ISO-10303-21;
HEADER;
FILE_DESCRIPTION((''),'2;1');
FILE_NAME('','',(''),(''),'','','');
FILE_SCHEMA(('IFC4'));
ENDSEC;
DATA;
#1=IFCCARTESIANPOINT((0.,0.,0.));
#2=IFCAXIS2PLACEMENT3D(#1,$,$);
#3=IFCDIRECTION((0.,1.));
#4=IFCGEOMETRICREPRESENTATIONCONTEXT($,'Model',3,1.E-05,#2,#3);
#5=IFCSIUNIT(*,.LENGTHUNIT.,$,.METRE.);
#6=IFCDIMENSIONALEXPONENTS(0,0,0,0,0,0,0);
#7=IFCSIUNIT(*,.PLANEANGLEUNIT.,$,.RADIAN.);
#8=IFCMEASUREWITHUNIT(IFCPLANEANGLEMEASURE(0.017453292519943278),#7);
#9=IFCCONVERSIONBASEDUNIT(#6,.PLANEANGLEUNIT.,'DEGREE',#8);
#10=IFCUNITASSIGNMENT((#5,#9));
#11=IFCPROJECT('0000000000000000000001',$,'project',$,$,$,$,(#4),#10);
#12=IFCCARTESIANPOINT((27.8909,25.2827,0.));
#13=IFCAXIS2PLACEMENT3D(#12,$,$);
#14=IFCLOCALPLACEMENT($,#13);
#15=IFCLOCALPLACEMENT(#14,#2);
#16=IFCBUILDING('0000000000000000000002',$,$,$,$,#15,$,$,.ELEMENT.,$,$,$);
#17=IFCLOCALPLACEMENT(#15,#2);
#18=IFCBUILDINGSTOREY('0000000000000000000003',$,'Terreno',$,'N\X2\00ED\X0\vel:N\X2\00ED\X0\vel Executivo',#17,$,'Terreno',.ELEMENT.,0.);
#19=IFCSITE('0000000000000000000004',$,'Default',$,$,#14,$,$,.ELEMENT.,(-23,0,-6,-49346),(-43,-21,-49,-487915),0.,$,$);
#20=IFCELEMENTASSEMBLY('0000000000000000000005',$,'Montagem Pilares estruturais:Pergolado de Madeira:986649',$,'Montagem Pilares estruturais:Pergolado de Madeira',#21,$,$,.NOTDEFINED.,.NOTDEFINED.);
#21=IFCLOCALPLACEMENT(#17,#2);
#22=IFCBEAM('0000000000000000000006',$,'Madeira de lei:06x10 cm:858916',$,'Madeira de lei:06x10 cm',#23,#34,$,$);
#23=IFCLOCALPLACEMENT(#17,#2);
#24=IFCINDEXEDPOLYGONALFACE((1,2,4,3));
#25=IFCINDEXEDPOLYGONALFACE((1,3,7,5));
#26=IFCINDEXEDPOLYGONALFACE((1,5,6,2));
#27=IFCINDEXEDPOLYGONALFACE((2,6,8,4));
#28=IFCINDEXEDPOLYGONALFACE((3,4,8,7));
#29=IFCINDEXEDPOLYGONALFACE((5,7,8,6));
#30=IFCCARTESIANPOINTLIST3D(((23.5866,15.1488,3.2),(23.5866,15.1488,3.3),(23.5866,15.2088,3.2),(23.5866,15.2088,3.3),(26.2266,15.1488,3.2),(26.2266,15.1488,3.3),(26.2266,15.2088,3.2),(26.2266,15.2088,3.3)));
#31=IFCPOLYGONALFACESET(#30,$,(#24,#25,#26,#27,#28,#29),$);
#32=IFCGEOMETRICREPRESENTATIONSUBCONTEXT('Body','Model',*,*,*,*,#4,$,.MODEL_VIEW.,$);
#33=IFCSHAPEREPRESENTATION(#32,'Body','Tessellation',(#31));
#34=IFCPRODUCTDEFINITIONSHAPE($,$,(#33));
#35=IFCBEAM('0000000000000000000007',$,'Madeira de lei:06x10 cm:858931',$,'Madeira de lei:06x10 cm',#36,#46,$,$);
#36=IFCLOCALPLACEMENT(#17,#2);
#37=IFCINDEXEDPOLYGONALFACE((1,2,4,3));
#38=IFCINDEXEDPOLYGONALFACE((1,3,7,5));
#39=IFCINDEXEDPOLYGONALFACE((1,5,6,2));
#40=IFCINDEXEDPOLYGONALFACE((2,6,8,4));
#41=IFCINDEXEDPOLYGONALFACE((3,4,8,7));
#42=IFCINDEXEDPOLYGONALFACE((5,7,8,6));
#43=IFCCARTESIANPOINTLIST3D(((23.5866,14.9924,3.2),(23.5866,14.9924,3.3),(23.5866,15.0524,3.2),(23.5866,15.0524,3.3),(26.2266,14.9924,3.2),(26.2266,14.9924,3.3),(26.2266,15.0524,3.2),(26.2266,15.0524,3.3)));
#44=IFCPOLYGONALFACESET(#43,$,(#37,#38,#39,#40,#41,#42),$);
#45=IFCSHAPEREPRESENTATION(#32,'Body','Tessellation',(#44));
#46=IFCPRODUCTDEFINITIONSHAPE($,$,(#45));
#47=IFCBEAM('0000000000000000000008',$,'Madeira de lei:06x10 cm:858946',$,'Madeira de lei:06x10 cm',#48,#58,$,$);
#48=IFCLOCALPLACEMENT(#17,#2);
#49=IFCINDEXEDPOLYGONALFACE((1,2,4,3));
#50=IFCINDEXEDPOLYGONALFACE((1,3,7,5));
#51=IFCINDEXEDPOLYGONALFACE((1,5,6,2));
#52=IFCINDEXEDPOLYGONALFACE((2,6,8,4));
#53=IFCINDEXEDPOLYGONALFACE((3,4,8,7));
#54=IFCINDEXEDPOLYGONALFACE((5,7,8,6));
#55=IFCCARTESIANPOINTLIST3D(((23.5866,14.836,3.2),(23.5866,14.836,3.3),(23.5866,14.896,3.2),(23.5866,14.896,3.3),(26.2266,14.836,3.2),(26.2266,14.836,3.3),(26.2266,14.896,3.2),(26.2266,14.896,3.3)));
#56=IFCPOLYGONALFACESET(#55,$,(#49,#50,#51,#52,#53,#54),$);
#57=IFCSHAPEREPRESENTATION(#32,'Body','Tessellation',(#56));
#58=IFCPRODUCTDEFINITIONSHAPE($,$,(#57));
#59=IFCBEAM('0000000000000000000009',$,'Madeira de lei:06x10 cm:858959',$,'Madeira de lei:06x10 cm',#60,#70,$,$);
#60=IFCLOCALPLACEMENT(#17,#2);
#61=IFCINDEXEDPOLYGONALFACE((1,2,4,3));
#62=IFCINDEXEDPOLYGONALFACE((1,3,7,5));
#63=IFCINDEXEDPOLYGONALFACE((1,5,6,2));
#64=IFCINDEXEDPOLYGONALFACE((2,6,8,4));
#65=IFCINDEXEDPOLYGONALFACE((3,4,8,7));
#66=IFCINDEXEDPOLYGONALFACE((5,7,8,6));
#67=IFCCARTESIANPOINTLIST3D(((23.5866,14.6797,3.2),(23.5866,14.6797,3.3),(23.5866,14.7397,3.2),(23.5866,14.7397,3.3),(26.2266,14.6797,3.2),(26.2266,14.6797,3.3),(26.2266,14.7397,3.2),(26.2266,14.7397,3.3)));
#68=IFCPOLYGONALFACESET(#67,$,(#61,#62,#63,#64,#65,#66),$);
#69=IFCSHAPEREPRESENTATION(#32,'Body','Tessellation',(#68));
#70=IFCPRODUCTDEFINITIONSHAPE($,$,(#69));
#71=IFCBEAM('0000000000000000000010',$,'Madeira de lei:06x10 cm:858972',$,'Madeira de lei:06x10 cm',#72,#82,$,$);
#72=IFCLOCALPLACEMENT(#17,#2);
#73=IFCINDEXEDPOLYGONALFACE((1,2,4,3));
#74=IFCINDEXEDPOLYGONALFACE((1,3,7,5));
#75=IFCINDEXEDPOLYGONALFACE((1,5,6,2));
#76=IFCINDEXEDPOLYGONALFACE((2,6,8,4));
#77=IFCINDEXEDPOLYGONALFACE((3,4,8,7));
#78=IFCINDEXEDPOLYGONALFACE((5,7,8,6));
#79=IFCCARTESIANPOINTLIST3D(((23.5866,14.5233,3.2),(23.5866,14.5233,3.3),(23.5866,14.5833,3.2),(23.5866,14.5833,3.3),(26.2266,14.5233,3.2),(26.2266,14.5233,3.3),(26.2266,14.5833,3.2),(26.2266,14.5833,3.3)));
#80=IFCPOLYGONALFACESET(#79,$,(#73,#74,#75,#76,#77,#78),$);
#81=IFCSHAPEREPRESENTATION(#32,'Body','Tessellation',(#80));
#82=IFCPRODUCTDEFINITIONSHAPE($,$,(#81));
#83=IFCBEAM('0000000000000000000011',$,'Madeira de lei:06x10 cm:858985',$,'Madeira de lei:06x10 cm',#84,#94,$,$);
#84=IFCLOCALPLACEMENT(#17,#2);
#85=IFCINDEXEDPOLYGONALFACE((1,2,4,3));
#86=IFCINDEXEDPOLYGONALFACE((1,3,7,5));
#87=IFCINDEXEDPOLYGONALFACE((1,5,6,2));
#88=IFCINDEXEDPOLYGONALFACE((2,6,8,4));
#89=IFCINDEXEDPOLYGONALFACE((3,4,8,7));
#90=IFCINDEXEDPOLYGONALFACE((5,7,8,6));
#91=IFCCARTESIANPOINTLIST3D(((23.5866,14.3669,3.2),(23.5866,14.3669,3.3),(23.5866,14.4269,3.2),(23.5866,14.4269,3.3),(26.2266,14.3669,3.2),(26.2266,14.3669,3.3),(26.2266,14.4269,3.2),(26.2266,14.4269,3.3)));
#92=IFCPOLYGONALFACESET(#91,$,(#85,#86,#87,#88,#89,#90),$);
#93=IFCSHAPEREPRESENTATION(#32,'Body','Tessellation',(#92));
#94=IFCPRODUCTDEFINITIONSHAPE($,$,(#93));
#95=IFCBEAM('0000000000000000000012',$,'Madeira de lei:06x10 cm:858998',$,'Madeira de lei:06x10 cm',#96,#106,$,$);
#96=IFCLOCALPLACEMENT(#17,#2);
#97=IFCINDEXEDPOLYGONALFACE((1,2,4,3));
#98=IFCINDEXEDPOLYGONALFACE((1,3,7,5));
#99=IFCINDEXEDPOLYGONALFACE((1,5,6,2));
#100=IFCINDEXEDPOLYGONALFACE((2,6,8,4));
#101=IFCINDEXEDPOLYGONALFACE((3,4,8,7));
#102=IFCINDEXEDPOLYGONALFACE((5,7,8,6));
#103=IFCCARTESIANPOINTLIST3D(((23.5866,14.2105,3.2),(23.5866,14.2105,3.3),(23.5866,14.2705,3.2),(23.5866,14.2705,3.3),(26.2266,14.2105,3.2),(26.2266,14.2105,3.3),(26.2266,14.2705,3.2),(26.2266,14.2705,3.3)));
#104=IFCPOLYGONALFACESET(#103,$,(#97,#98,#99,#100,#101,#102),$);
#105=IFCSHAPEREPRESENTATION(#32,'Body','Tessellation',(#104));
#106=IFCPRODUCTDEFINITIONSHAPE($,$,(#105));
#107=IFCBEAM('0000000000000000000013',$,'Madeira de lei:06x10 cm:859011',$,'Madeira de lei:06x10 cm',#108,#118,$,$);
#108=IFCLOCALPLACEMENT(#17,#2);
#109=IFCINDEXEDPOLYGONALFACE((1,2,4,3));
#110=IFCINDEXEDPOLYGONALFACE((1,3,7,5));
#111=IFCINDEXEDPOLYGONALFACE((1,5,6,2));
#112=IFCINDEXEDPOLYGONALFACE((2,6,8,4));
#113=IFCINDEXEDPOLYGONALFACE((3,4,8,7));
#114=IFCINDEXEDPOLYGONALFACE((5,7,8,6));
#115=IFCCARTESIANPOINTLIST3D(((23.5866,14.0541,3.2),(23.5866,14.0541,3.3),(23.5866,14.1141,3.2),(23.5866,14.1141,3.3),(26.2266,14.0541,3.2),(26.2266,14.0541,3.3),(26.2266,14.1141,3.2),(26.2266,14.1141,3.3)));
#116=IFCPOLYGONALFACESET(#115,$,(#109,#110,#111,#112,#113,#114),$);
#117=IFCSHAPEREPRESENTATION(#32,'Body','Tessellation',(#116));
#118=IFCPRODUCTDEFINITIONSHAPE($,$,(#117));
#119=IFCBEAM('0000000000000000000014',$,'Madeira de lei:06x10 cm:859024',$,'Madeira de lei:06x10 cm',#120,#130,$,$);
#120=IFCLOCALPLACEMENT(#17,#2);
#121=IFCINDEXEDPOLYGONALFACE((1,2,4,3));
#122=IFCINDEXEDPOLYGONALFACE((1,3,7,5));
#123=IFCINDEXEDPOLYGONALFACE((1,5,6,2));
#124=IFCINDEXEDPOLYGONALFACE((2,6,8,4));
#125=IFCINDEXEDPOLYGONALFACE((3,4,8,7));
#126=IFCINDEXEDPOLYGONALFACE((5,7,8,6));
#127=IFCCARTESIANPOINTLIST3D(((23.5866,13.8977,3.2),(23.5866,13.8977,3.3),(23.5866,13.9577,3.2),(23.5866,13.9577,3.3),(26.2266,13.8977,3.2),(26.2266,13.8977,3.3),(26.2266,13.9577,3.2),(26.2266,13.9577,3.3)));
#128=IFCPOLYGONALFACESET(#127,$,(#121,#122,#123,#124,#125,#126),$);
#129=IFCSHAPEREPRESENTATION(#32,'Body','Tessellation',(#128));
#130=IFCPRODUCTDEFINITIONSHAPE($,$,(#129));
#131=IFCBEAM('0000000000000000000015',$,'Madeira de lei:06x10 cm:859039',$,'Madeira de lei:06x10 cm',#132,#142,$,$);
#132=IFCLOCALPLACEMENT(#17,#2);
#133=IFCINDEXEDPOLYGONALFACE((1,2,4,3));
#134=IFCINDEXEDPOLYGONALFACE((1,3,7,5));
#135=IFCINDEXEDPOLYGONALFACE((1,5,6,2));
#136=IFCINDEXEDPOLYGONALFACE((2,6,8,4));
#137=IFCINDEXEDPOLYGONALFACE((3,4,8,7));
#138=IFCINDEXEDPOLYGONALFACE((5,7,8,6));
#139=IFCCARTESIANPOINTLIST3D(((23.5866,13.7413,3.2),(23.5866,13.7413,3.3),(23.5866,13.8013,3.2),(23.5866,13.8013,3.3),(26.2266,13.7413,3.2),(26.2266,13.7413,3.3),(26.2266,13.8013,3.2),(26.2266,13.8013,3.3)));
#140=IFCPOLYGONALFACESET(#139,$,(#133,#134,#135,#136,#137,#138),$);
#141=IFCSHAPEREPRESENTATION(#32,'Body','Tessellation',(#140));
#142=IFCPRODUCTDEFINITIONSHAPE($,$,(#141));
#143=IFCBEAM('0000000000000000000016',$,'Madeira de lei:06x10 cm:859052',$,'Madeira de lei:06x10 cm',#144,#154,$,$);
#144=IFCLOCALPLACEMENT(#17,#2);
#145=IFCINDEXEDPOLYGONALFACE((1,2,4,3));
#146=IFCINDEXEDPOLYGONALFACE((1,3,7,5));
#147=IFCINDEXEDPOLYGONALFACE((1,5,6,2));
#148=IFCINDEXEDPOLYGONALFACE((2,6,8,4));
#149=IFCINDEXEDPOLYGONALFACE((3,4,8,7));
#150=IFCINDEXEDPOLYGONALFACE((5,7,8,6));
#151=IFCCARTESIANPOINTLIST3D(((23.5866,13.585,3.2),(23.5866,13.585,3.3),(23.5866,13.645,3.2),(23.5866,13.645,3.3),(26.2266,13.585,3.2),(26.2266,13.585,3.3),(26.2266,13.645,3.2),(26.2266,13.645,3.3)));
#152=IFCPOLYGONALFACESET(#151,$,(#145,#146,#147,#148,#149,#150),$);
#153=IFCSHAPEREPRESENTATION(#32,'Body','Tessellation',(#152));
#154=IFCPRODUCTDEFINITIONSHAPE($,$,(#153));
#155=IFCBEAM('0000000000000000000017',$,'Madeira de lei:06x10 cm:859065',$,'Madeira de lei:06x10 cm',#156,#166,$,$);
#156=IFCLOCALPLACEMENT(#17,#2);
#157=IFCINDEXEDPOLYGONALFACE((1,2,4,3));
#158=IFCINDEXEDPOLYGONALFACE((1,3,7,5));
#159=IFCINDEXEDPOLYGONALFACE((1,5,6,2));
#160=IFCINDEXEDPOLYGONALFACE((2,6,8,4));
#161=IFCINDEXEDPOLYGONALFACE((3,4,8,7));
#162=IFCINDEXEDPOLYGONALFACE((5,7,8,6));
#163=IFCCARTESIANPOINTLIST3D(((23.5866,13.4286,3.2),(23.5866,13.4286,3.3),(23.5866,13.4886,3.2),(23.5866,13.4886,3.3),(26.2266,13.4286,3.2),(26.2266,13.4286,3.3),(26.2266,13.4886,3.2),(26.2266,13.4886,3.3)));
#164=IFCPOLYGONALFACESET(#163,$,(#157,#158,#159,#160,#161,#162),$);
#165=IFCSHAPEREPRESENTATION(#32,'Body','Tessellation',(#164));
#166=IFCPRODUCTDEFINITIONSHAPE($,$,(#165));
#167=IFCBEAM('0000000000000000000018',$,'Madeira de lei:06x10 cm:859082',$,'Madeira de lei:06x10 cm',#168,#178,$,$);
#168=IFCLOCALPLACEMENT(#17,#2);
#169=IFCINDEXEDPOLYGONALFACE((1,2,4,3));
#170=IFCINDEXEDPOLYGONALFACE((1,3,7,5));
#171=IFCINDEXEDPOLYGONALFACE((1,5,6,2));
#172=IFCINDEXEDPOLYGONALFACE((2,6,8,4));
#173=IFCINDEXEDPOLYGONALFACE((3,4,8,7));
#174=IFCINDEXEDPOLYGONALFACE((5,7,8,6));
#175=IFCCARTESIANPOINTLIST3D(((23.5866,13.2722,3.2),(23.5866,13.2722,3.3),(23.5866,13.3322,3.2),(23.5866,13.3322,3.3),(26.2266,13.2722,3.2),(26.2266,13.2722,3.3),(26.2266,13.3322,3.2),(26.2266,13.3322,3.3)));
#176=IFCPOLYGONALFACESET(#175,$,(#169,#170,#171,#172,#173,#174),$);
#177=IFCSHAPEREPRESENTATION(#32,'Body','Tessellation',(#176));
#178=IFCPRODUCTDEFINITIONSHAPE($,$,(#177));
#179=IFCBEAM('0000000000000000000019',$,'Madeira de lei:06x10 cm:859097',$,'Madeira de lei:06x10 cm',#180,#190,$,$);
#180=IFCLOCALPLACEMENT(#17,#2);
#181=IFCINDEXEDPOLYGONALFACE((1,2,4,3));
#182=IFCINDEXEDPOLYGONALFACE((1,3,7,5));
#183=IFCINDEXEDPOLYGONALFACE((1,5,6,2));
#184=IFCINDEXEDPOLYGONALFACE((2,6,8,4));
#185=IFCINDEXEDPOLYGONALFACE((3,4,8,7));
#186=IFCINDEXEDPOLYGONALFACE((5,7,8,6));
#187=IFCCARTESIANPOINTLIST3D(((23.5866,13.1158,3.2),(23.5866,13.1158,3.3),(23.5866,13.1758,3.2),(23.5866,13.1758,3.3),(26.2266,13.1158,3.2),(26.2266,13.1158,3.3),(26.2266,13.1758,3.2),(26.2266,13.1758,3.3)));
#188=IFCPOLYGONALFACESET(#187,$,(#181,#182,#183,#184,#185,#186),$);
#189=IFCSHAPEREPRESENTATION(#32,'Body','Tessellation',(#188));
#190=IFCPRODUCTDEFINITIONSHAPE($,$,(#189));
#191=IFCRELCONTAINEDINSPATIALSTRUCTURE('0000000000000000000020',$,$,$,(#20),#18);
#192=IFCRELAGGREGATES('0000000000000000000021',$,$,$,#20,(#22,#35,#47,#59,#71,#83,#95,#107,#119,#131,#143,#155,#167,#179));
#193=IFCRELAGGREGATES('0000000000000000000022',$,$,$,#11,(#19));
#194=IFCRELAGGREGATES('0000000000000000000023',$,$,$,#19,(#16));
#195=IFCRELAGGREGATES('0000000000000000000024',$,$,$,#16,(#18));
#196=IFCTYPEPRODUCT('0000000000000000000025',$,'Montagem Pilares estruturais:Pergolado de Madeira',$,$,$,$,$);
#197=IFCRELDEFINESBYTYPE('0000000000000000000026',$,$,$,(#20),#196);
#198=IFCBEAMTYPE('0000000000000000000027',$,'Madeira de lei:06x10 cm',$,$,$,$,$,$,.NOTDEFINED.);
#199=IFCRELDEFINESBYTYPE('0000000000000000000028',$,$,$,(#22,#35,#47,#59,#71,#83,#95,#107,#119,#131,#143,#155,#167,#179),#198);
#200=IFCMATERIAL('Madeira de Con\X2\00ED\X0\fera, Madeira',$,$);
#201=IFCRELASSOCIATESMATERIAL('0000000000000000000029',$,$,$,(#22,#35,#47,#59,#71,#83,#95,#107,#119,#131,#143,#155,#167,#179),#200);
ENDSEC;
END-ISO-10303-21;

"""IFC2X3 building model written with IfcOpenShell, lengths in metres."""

from ifc_helpers import new_model, entity, si_unit, converted_unit, direction, frame, frame_2d, origin, place, context, subcontext, project, spatial, rectangle, extrude, material, type_object, element, aggregate, save


model = new_model("IFC2X3")

# Units and contexts
model_context = context("Model", 3, precision=1e-05, world=origin(), true_north=direction((0.0, 1.0)))
body_context = subcontext(model_context, "Body", "Model", "MODEL_VIEW")
ifc_project = project(units=[si_unit("LENGTHUNIT", "METRE"), converted_unit("PLANEANGLEUNIT", "DEGREE", entity("IfcPlaneAngleMeasure", 0.017453292519943278), si_unit("PLANEANGLEUNIT", "RADIAN"), dimensions=[0, 0, 0, 0, 0, 0, 0])], contexts=[model_context])

# Site, building, storey
site_placement = place(None, frame((27.8909, 25.2827, 0.0)))
site = spatial("IfcSite", under=ifc_project, at=site_placement, Name="Default", CompositionType="ELEMENT", RefLatitude=(-23, 0, -6, -49346), RefLongitude=(-43, -21, -49, -487915), RefElevation=0.0)
building_placement = place(site_placement, origin())
building = spatial("IfcBuilding", under=site, at=building_placement, CompositionType="ELEMENT")
storey_placement = place(building_placement, origin())
storey = spatial("IfcBuildingStorey", under=building, at=storey_placement, Name="Terreno", ObjectType="Nível:Nível Executivo", LongName="Terreno", CompositionType="ELEMENT", Elevation=0.0)

# Element assembly, beams
type_product = type_object("IfcTypeProduct", Name="Montagem Pilares estruturais:Pergolado de Madeira")
assembly_placement = place(storey_placement, origin())
assembly = element("IfcElementAssembly", 1, at=assembly_placement, inside=storey, type_object=type_product, Name="Montagem Pilares estruturais:Pergolado de Madeira:986649", ObjectType="Montagem Pilares estruturais:Pergolado de Madeira", AssemblyPlace="NOTDEFINED", PredefinedType="NOTDEFINED")
ifc_material_1 = material(Name="Madeira de Conífera, Madeira")
beam_type_1 = type_object("IfcBeamType", Name="Madeira de lei:06x10 cm", PredefinedType="NOTDEFINED")
beam_1_placement = place(assembly_placement, frame((23.5866, 15.1788, 3.2)))
beam_1 = element("IfcBeam", 2, at=beam_1_placement, type_object=beam_type_1, material=ifc_material_1, Name="Madeira de lei:06x10 cm:858916", ObjectType="Madeira de lei:06x10 cm", context=body_context, shape_type="SweptSolid", body=[
    extrude(rectangle(XDim=0.1, YDim=0.06, at=frame_2d((0.0, 0.0), x_axis=(1.0, 0.0))), frame((0.0, 0.0, 0.05), z_axis=(1.0, 0.0, 0.0), x_axis=(0.0, 0.0, -1.0)), (0.0, 0.0, 1.0), 2.64),
])
beam_2_placement = place(assembly_placement, frame((23.5866, 15.0224, 3.2)))
beam_2 = element("IfcBeam", 3, at=beam_2_placement, type_object=beam_type_1, material=ifc_material_1, Name="Madeira de lei:06x10 cm:858931", ObjectType="Madeira de lei:06x10 cm", context=body_context, shape_type="SweptSolid", body=[
    extrude(rectangle(XDim=0.1, YDim=0.06, at=frame_2d((0.0, 0.0), x_axis=(1.0, 0.0))), frame((0.0, 0.0, 0.05), z_axis=(1.0, 0.0, 0.0), x_axis=(0.0, 0.0, -1.0)), (0.0, 0.0, 1.0), 2.64),
])
beam_3_placement = place(assembly_placement, frame((23.5866, 14.866, 3.2)))
beam_3 = element("IfcBeam", 4, at=beam_3_placement, type_object=beam_type_1, material=ifc_material_1, Name="Madeira de lei:06x10 cm:858946", ObjectType="Madeira de lei:06x10 cm", context=body_context, shape_type="SweptSolid", body=[
    extrude(rectangle(XDim=0.1, YDim=0.06, at=frame_2d((0.0, 0.0), x_axis=(1.0, 0.0))), frame((0.0, 0.0, 0.05), z_axis=(1.0, 0.0, 0.0), x_axis=(0.0, 0.0, -1.0)), (0.0, 0.0, 1.0), 2.64),
])
beam_4_placement = place(assembly_placement, frame((23.5866, 14.7097, 3.2)))
beam_4 = element("IfcBeam", 5, at=beam_4_placement, type_object=beam_type_1, material=ifc_material_1, Name="Madeira de lei:06x10 cm:858959", ObjectType="Madeira de lei:06x10 cm", context=body_context, shape_type="SweptSolid", body=[
    extrude(rectangle(XDim=0.1, YDim=0.06, at=frame_2d((0.0, 0.0), x_axis=(1.0, 0.0))), frame((0.0, 0.0, 0.05), z_axis=(1.0, 0.0, 0.0), x_axis=(0.0, 0.0, -1.0)), (0.0, 0.0, 1.0), 2.64),
])
beam_5_placement = place(assembly_placement, frame((23.5866, 14.5533, 3.2)))
beam_5 = element("IfcBeam", 6, at=beam_5_placement, type_object=beam_type_1, material=ifc_material_1, Name="Madeira de lei:06x10 cm:858972", ObjectType="Madeira de lei:06x10 cm", context=body_context, shape_type="SweptSolid", body=[
    extrude(rectangle(XDim=0.1, YDim=0.06, at=frame_2d((0.0, 0.0), x_axis=(1.0, 0.0))), frame((0.0, 0.0, 0.05), z_axis=(1.0, 0.0, 0.0), x_axis=(0.0, 0.0, -1.0)), (0.0, 0.0, 1.0), 2.64),
])
beam_6_placement = place(assembly_placement, frame((23.5866, 14.3969, 3.2)))
beam_6 = element("IfcBeam", 7, at=beam_6_placement, type_object=beam_type_1, material=ifc_material_1, Name="Madeira de lei:06x10 cm:858985", ObjectType="Madeira de lei:06x10 cm", context=body_context, shape_type="SweptSolid", body=[
    extrude(rectangle(XDim=0.1, YDim=0.06, at=frame_2d((0.0, 0.0), x_axis=(1.0, 0.0))), frame((0.0, 0.0, 0.05), z_axis=(1.0, 0.0, 0.0), x_axis=(0.0, 0.0, -1.0)), (0.0, 0.0, 1.0), 2.64),
])
beam_7_placement = place(assembly_placement, frame((23.5866, 14.2405, 3.2)))
beam_7 = element("IfcBeam", 8, at=beam_7_placement, type_object=beam_type_1, material=ifc_material_1, Name="Madeira de lei:06x10 cm:858998", ObjectType="Madeira de lei:06x10 cm", context=body_context, shape_type="SweptSolid", body=[
    extrude(rectangle(XDim=0.1, YDim=0.06, at=frame_2d((0.0, 0.0), x_axis=(1.0, 0.0))), frame((0.0, 0.0, 0.05), z_axis=(1.0, 0.0, 0.0), x_axis=(0.0, 0.0, -1.0)), (0.0, 0.0, 1.0), 2.64),
])
beam_8_placement = place(assembly_placement, frame((23.5866, 14.0841, 3.2)))
beam_8 = element("IfcBeam", 9, at=beam_8_placement, type_object=beam_type_1, material=ifc_material_1, Name="Madeira de lei:06x10 cm:859011", ObjectType="Madeira de lei:06x10 cm", context=body_context, shape_type="SweptSolid", body=[
    extrude(rectangle(XDim=0.1, YDim=0.06, at=frame_2d((0.0, 0.0), x_axis=(1.0, 0.0))), frame((0.0, 0.0, 0.05), z_axis=(1.0, 0.0, 0.0), x_axis=(0.0, 0.0, -1.0)), (0.0, 0.0, 1.0), 2.64),
])
beam_9_placement = place(assembly_placement, frame((23.5866, 13.9277, 3.2)))
beam_9 = element("IfcBeam", 10, at=beam_9_placement, type_object=beam_type_1, material=ifc_material_1, Name="Madeira de lei:06x10 cm:859024", ObjectType="Madeira de lei:06x10 cm", context=body_context, shape_type="SweptSolid", body=[
    extrude(rectangle(XDim=0.1, YDim=0.06, at=frame_2d((0.0, 0.0), x_axis=(1.0, 0.0))), frame((0.0, 0.0, 0.05), z_axis=(1.0, 0.0, 0.0), x_axis=(0.0, 0.0, -1.0)), (0.0, 0.0, 1.0), 2.64),
])
beam_10_placement = place(assembly_placement, frame((23.5866, 13.7713, 3.2)))
beam_10 = element("IfcBeam", 11, at=beam_10_placement, type_object=beam_type_1, material=ifc_material_1, Name="Madeira de lei:06x10 cm:859039", ObjectType="Madeira de lei:06x10 cm", context=body_context, shape_type="SweptSolid", body=[
    extrude(rectangle(XDim=0.1, YDim=0.06, at=frame_2d((0.0, 0.0), x_axis=(1.0, 0.0))), frame((0.0, 0.0, 0.05), z_axis=(1.0, 0.0, 0.0), x_axis=(0.0, 0.0, -1.0)), (0.0, 0.0, 1.0), 2.64),
])
beam_11_placement = place(assembly_placement, frame((23.5866, 13.615, 3.2)))
beam_11 = element("IfcBeam", 12, at=beam_11_placement, type_object=beam_type_1, material=ifc_material_1, Name="Madeira de lei:06x10 cm:859052", ObjectType="Madeira de lei:06x10 cm", context=body_context, shape_type="SweptSolid", body=[
    extrude(rectangle(XDim=0.1, YDim=0.06, at=frame_2d((0.0, 0.0), x_axis=(1.0, 0.0))), frame((0.0, 0.0, 0.05), z_axis=(1.0, 0.0, 0.0), x_axis=(0.0, 0.0, -1.0)), (0.0, 0.0, 1.0), 2.64),
])
beam_12_placement = place(assembly_placement, frame((23.5866, 13.4586, 3.2)))
beam_12 = element("IfcBeam", 13, at=beam_12_placement, type_object=beam_type_1, material=ifc_material_1, Name="Madeira de lei:06x10 cm:859065", ObjectType="Madeira de lei:06x10 cm", context=body_context, shape_type="SweptSolid", body=[
    extrude(rectangle(XDim=0.1, YDim=0.06, at=frame_2d((0.0, 0.0), x_axis=(1.0, 0.0))), frame((0.0, 0.0, 0.05), z_axis=(1.0, 0.0, 0.0), x_axis=(0.0, 0.0, -1.0)), (0.0, 0.0, 1.0), 2.64),
])
beam_13_placement = place(assembly_placement, frame((23.5866, 13.3022, 3.2)))
beam_13 = element("IfcBeam", 14, at=beam_13_placement, type_object=beam_type_1, material=ifc_material_1, Name="Madeira de lei:06x10 cm:859082", ObjectType="Madeira de lei:06x10 cm", context=body_context, shape_type="SweptSolid", body=[
    extrude(rectangle(XDim=0.1, YDim=0.06, at=frame_2d((0.0, 0.0), x_axis=(1.0, 0.0))), frame((0.0, 0.0, 0.05), z_axis=(1.0, 0.0, 0.0), x_axis=(0.0, 0.0, -1.0)), (0.0, 0.0, 1.0), 2.64),
])
beam_14_placement = place(assembly_placement, frame((23.5866, 13.1458, 3.2)))
beam_14 = element("IfcBeam", 15, at=beam_14_placement, type_object=beam_type_1, material=ifc_material_1, Name="Madeira de lei:06x10 cm:859097", ObjectType="Madeira de lei:06x10 cm", context=body_context, shape_type="SweptSolid", body=[
    extrude(rectangle(XDim=0.1, YDim=0.06, at=frame_2d((0.0, 0.0), x_axis=(1.0, 0.0))), frame((0.0, 0.0, 0.05), z_axis=(1.0, 0.0, 0.0), x_axis=(0.0, 0.0, -1.0)), (0.0, 0.0, 1.0), 2.64),
])
aggregate(assembly, [beam_1, beam_2, beam_3, beam_4, beam_5, beam_6, beam_7, beam_8, beam_9, beam_10, beam_11, beam_12, beam_13, beam_14])

save(model, "model.ifc")
